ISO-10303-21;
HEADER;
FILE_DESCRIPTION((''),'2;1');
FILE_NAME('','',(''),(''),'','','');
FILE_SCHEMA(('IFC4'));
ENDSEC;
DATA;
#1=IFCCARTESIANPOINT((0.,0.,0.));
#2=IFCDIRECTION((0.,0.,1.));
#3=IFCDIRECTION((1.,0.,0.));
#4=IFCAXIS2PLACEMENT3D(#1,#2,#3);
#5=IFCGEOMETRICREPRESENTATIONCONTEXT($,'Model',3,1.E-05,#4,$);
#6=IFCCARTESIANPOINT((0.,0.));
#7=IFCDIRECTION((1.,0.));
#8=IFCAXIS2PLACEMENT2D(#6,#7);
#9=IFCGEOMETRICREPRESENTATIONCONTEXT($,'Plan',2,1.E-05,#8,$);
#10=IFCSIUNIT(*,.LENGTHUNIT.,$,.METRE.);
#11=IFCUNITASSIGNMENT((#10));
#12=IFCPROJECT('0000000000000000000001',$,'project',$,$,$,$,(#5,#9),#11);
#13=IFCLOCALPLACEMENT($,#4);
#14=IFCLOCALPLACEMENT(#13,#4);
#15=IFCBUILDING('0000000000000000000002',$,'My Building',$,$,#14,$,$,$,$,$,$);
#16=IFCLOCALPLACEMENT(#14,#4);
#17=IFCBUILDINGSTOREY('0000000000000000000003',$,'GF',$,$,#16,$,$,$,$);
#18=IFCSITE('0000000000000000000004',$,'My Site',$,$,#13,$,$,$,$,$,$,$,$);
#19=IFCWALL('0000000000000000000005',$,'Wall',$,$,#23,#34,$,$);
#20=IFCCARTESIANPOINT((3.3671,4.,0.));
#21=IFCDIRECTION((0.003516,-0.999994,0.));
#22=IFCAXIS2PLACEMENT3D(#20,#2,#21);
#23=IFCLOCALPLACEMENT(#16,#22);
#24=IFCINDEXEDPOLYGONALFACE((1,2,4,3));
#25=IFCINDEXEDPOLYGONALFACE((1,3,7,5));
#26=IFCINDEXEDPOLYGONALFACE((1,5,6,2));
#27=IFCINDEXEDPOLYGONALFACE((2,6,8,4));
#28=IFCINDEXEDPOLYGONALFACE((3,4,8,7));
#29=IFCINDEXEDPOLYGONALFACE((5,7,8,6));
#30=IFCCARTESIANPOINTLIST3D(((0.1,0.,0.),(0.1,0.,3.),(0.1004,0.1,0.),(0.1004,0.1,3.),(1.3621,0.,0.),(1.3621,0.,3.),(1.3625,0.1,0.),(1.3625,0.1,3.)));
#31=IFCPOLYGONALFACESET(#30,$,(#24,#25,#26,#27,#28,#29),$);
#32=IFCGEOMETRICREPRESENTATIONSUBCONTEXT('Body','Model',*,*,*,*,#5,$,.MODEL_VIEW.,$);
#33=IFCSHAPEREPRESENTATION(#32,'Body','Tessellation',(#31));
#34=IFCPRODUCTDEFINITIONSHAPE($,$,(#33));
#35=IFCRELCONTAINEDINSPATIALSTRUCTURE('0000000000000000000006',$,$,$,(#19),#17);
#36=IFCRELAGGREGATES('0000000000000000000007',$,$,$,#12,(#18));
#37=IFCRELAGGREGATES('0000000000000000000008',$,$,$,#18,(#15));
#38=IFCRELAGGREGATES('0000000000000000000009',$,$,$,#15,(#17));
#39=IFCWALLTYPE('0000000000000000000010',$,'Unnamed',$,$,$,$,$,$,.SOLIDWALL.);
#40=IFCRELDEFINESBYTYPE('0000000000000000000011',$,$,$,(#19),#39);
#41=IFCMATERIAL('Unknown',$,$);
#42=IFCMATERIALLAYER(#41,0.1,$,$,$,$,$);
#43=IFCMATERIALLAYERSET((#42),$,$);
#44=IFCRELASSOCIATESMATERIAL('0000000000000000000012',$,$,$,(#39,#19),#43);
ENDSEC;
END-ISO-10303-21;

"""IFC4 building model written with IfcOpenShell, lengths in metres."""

from ifc_helpers import new_model, si_unit, frame, origin_with_axes, origin_2d_with_axis, place, context, subcontext, project, spatial, line, indexed_curve, outline, extrude, material, layer, layer_set, layer_usage, type_object, element, save


model = new_model("IFC4")

# Units and contexts
model_context = context("Model", 3, precision=1e-05, world=origin_with_axes())
plan_context = context("Plan", 2, precision=1e-05, world=origin_2d_with_axis())
body_context_1 = subcontext(model_context, "Body", "Model", "MODEL_VIEW")
ifc_project = project(units=[si_unit("LENGTHUNIT", "METRE")], contexts=[model_context, plan_context])

# Site, building, storey
site_placement = place(None, origin_with_axes())
site = spatial("IfcSite", under=ifc_project, at=site_placement, Name="My Site")
building_placement = place(site_placement, origin_with_axes())
building = spatial("IfcBuilding", under=site, at=building_placement, Name="My Building")
storey_placement = place(building_placement, origin_with_axes())
storey = spatial("IfcBuildingStorey", under=building, at=storey_placement, Name="GF")

# Shared definitions
ifc_material = material(Name="Unknown")

# Wall
ifc_layer_1 = layer(ifc_material, 0.1)
ifc_layer_set_1 = layer_set([ifc_layer_1])
wall_type = type_object("IfcWallType", Name="Unnamed", PredefinedType="SOLIDWALL", material=ifc_layer_set_1)
ifc_layer_usage_1 = layer_usage(ifc_layer_set_1, "AXIS2", "POSITIVE", 0.0)
wall_1_placement = place(storey_placement, frame((3.3671, 4.0, 0.0), z_axis=(0.0, 0.0, 1.0), x_axis=(0.003516, -0.999994, 0.0)))
element("IfcWall", 1, at=wall_1_placement, inside=storey, type_object=wall_type, material=ifc_layer_usage_1, Name="Wall", context=body_context_1, shape_type="SweptSolid", body=[
    extrude(outline(indexed_curve([(0.1, 0.0), (0.1004, 0.1), (1.3625, 0.1), (1.3621, 0.0)], segments=[line(1, 2, 3, 4, 1)])), origin_with_axes(), (0.0, 0.0, 1.0), 3.0),
])

save(model, "model.ifc")
